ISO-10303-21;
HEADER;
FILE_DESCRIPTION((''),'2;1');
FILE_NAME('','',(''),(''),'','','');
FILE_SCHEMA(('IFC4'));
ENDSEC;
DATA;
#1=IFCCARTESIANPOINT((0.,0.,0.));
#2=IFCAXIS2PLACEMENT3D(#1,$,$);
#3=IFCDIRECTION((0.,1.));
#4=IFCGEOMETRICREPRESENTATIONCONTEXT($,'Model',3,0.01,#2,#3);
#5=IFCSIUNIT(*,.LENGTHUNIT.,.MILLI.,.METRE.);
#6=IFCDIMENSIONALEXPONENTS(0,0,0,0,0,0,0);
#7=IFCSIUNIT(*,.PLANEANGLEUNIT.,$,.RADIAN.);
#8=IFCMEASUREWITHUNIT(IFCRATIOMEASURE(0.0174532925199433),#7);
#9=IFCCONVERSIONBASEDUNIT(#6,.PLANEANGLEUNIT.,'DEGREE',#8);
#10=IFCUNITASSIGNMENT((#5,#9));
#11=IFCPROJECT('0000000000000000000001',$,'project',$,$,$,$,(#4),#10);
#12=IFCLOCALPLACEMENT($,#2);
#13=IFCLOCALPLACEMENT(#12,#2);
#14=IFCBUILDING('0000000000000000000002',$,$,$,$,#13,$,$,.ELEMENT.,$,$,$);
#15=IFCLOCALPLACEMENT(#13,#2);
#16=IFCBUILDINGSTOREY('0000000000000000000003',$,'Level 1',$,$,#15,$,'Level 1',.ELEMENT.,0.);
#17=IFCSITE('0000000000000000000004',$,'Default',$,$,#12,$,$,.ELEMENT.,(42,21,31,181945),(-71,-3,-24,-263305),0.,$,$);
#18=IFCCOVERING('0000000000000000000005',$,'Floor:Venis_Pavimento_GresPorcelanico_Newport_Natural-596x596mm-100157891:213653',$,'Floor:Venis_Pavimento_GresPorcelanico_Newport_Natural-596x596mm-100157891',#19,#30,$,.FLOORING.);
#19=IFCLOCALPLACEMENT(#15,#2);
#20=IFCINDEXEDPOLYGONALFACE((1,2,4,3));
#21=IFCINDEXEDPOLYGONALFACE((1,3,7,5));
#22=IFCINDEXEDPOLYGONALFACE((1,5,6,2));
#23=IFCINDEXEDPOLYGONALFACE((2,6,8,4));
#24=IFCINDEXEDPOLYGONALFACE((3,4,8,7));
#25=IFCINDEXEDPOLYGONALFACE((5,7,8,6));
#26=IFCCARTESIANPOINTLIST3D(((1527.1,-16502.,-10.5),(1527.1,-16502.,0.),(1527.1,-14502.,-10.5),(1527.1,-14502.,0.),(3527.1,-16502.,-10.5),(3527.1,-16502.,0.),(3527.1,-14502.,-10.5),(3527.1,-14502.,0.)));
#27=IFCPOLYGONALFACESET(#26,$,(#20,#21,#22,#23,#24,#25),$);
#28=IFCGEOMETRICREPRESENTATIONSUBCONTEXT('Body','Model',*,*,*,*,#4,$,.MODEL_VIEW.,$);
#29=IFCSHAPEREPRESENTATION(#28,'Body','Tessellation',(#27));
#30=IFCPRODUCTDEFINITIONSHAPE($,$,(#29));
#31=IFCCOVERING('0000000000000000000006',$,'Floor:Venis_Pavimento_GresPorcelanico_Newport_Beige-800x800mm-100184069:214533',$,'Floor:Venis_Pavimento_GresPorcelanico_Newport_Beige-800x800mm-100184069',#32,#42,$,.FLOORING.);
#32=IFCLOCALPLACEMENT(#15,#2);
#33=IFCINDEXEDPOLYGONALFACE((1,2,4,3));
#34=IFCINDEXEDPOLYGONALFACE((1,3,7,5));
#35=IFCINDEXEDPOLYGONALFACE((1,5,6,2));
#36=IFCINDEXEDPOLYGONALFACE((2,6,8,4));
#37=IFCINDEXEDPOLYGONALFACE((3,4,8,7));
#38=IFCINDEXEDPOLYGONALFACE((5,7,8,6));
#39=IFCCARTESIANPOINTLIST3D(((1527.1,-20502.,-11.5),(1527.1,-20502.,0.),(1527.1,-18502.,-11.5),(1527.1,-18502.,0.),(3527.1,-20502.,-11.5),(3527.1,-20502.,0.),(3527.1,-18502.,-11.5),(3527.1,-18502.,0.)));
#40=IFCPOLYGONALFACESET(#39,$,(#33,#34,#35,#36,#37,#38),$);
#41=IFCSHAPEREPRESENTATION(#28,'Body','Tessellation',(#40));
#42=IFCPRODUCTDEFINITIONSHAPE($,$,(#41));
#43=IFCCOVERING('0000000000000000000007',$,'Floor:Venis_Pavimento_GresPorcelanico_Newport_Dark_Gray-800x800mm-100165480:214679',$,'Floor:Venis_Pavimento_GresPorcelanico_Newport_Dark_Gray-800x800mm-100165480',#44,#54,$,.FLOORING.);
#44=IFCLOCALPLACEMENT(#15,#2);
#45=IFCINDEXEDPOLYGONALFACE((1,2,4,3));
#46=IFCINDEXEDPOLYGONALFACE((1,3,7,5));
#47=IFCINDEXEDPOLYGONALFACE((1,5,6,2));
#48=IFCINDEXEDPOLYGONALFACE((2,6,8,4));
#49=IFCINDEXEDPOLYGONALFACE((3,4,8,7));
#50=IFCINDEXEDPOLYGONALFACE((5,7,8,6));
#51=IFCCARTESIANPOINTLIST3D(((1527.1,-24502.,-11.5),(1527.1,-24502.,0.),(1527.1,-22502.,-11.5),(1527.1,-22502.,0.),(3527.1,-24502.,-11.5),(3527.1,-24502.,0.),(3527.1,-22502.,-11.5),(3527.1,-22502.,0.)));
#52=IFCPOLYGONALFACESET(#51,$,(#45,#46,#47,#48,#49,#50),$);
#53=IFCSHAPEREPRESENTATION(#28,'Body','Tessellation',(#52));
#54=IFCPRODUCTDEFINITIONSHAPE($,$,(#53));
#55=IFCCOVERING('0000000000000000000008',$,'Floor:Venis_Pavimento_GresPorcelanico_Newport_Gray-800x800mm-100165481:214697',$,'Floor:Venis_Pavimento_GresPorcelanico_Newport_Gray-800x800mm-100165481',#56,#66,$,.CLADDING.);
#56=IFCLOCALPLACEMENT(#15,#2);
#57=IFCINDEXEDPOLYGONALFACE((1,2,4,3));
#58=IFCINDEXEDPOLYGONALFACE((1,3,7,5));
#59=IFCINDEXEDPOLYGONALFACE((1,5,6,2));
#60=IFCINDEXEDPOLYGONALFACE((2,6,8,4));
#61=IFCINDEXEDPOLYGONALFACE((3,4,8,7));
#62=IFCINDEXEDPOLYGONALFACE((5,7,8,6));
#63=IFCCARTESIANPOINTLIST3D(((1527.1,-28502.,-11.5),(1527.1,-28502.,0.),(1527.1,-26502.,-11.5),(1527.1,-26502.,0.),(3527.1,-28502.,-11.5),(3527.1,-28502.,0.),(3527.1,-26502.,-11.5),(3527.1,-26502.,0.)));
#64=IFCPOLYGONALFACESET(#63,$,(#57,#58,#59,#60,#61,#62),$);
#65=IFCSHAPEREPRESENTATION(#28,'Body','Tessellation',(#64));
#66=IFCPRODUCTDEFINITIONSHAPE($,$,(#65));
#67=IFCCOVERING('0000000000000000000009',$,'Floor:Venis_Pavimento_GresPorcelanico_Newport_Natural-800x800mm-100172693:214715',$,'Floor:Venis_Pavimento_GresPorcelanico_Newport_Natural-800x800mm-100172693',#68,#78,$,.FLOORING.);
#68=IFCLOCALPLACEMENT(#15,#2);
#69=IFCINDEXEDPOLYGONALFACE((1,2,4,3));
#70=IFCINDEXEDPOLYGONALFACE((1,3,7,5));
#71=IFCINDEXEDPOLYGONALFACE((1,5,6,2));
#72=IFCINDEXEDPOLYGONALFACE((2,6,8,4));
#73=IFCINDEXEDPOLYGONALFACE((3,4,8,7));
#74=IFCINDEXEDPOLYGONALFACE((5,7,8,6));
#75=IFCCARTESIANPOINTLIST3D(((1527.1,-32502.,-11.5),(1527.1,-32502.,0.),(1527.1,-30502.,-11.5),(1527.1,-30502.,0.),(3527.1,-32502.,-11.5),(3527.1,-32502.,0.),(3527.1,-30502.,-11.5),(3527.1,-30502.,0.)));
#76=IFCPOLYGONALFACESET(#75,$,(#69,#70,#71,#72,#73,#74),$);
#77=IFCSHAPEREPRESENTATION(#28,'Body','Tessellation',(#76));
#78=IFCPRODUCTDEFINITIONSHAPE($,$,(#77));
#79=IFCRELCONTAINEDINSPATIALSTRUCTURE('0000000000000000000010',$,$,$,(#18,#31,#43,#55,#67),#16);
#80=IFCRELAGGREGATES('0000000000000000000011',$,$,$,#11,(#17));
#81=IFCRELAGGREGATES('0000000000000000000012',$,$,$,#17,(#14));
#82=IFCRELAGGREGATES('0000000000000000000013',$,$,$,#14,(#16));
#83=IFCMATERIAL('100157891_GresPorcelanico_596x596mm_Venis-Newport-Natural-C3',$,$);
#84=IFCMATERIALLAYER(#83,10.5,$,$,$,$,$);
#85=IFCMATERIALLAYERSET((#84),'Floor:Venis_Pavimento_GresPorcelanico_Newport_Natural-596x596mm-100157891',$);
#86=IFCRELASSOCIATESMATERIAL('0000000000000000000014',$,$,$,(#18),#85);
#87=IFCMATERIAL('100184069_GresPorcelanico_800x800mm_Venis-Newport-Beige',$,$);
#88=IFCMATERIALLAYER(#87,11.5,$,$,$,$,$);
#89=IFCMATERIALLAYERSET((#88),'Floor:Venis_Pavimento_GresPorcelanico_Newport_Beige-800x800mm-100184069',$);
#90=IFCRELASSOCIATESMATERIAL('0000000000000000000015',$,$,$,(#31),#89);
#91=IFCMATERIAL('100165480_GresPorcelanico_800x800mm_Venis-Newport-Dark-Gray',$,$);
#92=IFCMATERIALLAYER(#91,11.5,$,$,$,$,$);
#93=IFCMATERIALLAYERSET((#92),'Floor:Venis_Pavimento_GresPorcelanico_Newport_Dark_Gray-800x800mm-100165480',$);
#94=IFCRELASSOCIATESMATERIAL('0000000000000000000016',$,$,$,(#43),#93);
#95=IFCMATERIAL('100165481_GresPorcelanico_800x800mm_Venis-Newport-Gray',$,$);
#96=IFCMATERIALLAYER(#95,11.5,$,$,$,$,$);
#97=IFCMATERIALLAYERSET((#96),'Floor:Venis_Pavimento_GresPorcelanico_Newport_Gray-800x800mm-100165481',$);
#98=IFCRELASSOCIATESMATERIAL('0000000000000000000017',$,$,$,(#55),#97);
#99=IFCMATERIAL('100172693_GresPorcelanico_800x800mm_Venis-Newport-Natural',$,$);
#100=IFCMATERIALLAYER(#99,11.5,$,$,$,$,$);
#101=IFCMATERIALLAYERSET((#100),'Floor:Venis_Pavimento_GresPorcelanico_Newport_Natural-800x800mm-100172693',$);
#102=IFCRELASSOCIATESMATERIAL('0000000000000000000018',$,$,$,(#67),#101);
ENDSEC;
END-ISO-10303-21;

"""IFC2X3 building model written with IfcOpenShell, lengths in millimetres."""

from ifc_helpers import new_model, entity, si_unit, converted_unit, direction, frame, frame_2d, origin, place, context, subcontext, project, spatial, rectangle, extrude, material, layer, layer_set, layer_usage, element, save


model = new_model("IFC2X3")

# Units and contexts
model_context = context("Model", 3, precision=0.01, world=origin(), true_north=direction((0.0, 1.0)))
body_context = subcontext(model_context, "Body", "Model", "MODEL_VIEW")
ifc_project = project(units=[si_unit("LENGTHUNIT", "METRE", prefix="MILLI"), converted_unit("PLANEANGLEUNIT", "DEGREE", entity("IfcRatioMeasure", 0.0174532925199433), si_unit("PLANEANGLEUNIT", "RADIAN"), dimensions=[0, 0, 0, 0, 0, 0, 0])], contexts=[model_context])

# Site, building, storey
site_placement = place(None, origin())
site = spatial("IfcSite", under=ifc_project, at=site_placement, Name="Default", CompositionType="ELEMENT", RefLatitude=(42, 21, 31, 181945), RefLongitude=(-71, -3, -24, -263305), RefElevation=0.0)
building_placement = place(site_placement, origin())
building = spatial("IfcBuilding", under=site, at=building_placement, CompositionType="ELEMENT")
storey_placement = place(building_placement, origin())
storey = spatial("IfcBuildingStorey", under=building, at=storey_placement, Name="Level 1", LongName="Level 1", CompositionType="ELEMENT", Elevation=0.0)

# Shared definitions
ifc_material_1 = material(Name="100157891_GresPorcelanico_596x596mm_Venis-Newport-Natural-C3")
ifc_material_2 = material(Name="100184069_GresPorcelanico_800x800mm_Venis-Newport-Beige")
ifc_material_3 = material(Name="100165480_GresPorcelanico_800x800mm_Venis-Newport-Dark-Gray")
ifc_material_4 = material(Name="100165481_GresPorcelanico_800x800mm_Venis-Newport-Gray")
ifc_material_5 = material(Name="100172693_GresPorcelanico_800x800mm_Venis-Newport-Natural")

# Coverings
ifc_layer_1 = layer(ifc_material_1, 10.5)
ifc_layer_set_1 = layer_set([ifc_layer_1], Name="Floor:Venis_Pavimento_GresPorcelanico_Newport_Natural-596x596mm-100157891")
ifc_layer_usage_1 = layer_usage(ifc_layer_set_1, "AXIS3", "POSITIVE", 0.0)
covering_1_placement = place(storey_placement, origin())
element("IfcCovering", 1, at=covering_1_placement, inside=storey, material=ifc_layer_usage_1, Name="Floor:Venis_Pavimento_GresPorcelanico_Newport_Natural-596x596mm-100157891:213653", ObjectType="Floor:Venis_Pavimento_GresPorcelanico_Newport_Natural-596x596mm-100157891", PredefinedType="FLOORING", context=body_context, shape_type="SweptSolid", body=[
    extrude(rectangle(XDim=2000.0, YDim=2000.0, at=frame_2d((0.0, 0.0), x_axis=(1.0, 0.0))), frame((2527.1, -15502.0, 0.0), z_axis=(0.0, 0.0, -1.0), x_axis=(0.0, 1.0, 0.0)), (0.0, 0.0, 1.0), 10.5),
])
ifc_layer_2 = layer(ifc_material_2, 11.5)
ifc_layer_set_2 = layer_set([ifc_layer_2], Name="Floor:Venis_Pavimento_GresPorcelanico_Newport_Beige-800x800mm-100184069")
ifc_layer_usage_2 = layer_usage(ifc_layer_set_2, "AXIS3", "POSITIVE", 0.0)
covering_2_placement = place(storey_placement, origin())
element("IfcCovering", 2, at=covering_2_placement, inside=storey, material=ifc_layer_usage_2, Name="Floor:Venis_Pavimento_GresPorcelanico_Newport_Beige-800x800mm-100184069:214533", ObjectType="Floor:Venis_Pavimento_GresPorcelanico_Newport_Beige-800x800mm-100184069", PredefinedType="FLOORING", context=body_context, shape_type="SweptSolid", body=[
    extrude(rectangle(XDim=2000.0, YDim=2000.0, at=frame_2d((0.0, 0.0), x_axis=(1.0, 0.0))), frame((2527.1, -19502.0, 0.0), z_axis=(0.0, 0.0, -1.0), x_axis=(0.0, 1.0, 0.0)), (0.0, 0.0, 1.0), 11.5),
])
ifc_layer_3 = layer(ifc_material_3, 11.5)
ifc_layer_set_3 = layer_set([ifc_layer_3], Name="Floor:Venis_Pavimento_GresPorcelanico_Newport_Dark_Gray-800x800mm-100165480")
ifc_layer_usage_3 = layer_usage(ifc_layer_set_3, "AXIS3", "POSITIVE", 0.0)
covering_3_placement = place(storey_placement, origin())
element("IfcCovering", 3, at=covering_3_placement, inside=storey, material=ifc_layer_usage_3, Name="Floor:Venis_Pavimento_GresPorcelanico_Newport_Dark_Gray-800x800mm-100165480:214679", ObjectType="Floor:Venis_Pavimento_GresPorcelanico_Newport_Dark_Gray-800x800mm-100165480", PredefinedType="FLOORING", context=body_context, shape_type="SweptSolid", body=[
    extrude(rectangle(XDim=2000.0, YDim=2000.0, at=frame_2d((0.0, 0.0), x_axis=(1.0, 0.0))), frame((2527.1, -23502.0, 0.0), z_axis=(0.0, 0.0, -1.0), x_axis=(0.0, 1.0, 0.0)), (0.0, 0.0, 1.0), 11.5),
])
ifc_layer_4 = layer(ifc_material_4, 11.5)
ifc_layer_set_4 = layer_set([ifc_layer_4], Name="Floor:Venis_Pavimento_GresPorcelanico_Newport_Gray-800x800mm-100165481")
ifc_layer_usage_4 = layer_usage(ifc_layer_set_4, "AXIS3", "POSITIVE", 0.0)
covering_4_placement = place(storey_placement, origin())
element("IfcCovering", 4, at=covering_4_placement, inside=storey, material=ifc_layer_usage_4, Name="Floor:Venis_Pavimento_GresPorcelanico_Newport_Gray-800x800mm-100165481:214697", ObjectType="Floor:Venis_Pavimento_GresPorcelanico_Newport_Gray-800x800mm-100165481", PredefinedType="CLADDING", context=body_context, shape_type="SweptSolid", body=[
    extrude(rectangle(XDim=2000.0, YDim=2000.0, at=frame_2d((0.0, 0.0), x_axis=(1.0, 0.0))), frame((2527.1, -27502.0, 0.0), z_axis=(0.0, 0.0, -1.0), x_axis=(0.0, 1.0, 0.0)), (0.0, 0.0, 1.0), 11.5),
])
ifc_layer_5 = layer(ifc_material_5, 11.5)
ifc_layer_set_5 = layer_set([ifc_layer_5], Name="Floor:Venis_Pavimento_GresPorcelanico_Newport_Natural-800x800mm-100172693")
ifc_layer_usage_5 = layer_usage(ifc_layer_set_5, "AXIS3", "POSITIVE", 0.0)
covering_5_placement = place(storey_placement, origin())
element("IfcCovering", 5, at=covering_5_placement, inside=storey, material=ifc_layer_usage_5, Name="Floor:Venis_Pavimento_GresPorcelanico_Newport_Natural-800x800mm-100172693:214715", ObjectType="Floor:Venis_Pavimento_GresPorcelanico_Newport_Natural-800x800mm-100172693", PredefinedType="FLOORING", context=body_context, shape_type="SweptSolid", body=[
    extrude(rectangle(XDim=2000.0, YDim=2000.0, at=frame_2d((0.0, 0.0), x_axis=(1.0, 0.0))), frame((2527.1, -31502.0, 0.0), z_axis=(0.0, 0.0, -1.0), x_axis=(0.0, 1.0, 0.0)), (0.0, 0.0, 1.0), 11.5),
])

save(model, "model.ifc")
